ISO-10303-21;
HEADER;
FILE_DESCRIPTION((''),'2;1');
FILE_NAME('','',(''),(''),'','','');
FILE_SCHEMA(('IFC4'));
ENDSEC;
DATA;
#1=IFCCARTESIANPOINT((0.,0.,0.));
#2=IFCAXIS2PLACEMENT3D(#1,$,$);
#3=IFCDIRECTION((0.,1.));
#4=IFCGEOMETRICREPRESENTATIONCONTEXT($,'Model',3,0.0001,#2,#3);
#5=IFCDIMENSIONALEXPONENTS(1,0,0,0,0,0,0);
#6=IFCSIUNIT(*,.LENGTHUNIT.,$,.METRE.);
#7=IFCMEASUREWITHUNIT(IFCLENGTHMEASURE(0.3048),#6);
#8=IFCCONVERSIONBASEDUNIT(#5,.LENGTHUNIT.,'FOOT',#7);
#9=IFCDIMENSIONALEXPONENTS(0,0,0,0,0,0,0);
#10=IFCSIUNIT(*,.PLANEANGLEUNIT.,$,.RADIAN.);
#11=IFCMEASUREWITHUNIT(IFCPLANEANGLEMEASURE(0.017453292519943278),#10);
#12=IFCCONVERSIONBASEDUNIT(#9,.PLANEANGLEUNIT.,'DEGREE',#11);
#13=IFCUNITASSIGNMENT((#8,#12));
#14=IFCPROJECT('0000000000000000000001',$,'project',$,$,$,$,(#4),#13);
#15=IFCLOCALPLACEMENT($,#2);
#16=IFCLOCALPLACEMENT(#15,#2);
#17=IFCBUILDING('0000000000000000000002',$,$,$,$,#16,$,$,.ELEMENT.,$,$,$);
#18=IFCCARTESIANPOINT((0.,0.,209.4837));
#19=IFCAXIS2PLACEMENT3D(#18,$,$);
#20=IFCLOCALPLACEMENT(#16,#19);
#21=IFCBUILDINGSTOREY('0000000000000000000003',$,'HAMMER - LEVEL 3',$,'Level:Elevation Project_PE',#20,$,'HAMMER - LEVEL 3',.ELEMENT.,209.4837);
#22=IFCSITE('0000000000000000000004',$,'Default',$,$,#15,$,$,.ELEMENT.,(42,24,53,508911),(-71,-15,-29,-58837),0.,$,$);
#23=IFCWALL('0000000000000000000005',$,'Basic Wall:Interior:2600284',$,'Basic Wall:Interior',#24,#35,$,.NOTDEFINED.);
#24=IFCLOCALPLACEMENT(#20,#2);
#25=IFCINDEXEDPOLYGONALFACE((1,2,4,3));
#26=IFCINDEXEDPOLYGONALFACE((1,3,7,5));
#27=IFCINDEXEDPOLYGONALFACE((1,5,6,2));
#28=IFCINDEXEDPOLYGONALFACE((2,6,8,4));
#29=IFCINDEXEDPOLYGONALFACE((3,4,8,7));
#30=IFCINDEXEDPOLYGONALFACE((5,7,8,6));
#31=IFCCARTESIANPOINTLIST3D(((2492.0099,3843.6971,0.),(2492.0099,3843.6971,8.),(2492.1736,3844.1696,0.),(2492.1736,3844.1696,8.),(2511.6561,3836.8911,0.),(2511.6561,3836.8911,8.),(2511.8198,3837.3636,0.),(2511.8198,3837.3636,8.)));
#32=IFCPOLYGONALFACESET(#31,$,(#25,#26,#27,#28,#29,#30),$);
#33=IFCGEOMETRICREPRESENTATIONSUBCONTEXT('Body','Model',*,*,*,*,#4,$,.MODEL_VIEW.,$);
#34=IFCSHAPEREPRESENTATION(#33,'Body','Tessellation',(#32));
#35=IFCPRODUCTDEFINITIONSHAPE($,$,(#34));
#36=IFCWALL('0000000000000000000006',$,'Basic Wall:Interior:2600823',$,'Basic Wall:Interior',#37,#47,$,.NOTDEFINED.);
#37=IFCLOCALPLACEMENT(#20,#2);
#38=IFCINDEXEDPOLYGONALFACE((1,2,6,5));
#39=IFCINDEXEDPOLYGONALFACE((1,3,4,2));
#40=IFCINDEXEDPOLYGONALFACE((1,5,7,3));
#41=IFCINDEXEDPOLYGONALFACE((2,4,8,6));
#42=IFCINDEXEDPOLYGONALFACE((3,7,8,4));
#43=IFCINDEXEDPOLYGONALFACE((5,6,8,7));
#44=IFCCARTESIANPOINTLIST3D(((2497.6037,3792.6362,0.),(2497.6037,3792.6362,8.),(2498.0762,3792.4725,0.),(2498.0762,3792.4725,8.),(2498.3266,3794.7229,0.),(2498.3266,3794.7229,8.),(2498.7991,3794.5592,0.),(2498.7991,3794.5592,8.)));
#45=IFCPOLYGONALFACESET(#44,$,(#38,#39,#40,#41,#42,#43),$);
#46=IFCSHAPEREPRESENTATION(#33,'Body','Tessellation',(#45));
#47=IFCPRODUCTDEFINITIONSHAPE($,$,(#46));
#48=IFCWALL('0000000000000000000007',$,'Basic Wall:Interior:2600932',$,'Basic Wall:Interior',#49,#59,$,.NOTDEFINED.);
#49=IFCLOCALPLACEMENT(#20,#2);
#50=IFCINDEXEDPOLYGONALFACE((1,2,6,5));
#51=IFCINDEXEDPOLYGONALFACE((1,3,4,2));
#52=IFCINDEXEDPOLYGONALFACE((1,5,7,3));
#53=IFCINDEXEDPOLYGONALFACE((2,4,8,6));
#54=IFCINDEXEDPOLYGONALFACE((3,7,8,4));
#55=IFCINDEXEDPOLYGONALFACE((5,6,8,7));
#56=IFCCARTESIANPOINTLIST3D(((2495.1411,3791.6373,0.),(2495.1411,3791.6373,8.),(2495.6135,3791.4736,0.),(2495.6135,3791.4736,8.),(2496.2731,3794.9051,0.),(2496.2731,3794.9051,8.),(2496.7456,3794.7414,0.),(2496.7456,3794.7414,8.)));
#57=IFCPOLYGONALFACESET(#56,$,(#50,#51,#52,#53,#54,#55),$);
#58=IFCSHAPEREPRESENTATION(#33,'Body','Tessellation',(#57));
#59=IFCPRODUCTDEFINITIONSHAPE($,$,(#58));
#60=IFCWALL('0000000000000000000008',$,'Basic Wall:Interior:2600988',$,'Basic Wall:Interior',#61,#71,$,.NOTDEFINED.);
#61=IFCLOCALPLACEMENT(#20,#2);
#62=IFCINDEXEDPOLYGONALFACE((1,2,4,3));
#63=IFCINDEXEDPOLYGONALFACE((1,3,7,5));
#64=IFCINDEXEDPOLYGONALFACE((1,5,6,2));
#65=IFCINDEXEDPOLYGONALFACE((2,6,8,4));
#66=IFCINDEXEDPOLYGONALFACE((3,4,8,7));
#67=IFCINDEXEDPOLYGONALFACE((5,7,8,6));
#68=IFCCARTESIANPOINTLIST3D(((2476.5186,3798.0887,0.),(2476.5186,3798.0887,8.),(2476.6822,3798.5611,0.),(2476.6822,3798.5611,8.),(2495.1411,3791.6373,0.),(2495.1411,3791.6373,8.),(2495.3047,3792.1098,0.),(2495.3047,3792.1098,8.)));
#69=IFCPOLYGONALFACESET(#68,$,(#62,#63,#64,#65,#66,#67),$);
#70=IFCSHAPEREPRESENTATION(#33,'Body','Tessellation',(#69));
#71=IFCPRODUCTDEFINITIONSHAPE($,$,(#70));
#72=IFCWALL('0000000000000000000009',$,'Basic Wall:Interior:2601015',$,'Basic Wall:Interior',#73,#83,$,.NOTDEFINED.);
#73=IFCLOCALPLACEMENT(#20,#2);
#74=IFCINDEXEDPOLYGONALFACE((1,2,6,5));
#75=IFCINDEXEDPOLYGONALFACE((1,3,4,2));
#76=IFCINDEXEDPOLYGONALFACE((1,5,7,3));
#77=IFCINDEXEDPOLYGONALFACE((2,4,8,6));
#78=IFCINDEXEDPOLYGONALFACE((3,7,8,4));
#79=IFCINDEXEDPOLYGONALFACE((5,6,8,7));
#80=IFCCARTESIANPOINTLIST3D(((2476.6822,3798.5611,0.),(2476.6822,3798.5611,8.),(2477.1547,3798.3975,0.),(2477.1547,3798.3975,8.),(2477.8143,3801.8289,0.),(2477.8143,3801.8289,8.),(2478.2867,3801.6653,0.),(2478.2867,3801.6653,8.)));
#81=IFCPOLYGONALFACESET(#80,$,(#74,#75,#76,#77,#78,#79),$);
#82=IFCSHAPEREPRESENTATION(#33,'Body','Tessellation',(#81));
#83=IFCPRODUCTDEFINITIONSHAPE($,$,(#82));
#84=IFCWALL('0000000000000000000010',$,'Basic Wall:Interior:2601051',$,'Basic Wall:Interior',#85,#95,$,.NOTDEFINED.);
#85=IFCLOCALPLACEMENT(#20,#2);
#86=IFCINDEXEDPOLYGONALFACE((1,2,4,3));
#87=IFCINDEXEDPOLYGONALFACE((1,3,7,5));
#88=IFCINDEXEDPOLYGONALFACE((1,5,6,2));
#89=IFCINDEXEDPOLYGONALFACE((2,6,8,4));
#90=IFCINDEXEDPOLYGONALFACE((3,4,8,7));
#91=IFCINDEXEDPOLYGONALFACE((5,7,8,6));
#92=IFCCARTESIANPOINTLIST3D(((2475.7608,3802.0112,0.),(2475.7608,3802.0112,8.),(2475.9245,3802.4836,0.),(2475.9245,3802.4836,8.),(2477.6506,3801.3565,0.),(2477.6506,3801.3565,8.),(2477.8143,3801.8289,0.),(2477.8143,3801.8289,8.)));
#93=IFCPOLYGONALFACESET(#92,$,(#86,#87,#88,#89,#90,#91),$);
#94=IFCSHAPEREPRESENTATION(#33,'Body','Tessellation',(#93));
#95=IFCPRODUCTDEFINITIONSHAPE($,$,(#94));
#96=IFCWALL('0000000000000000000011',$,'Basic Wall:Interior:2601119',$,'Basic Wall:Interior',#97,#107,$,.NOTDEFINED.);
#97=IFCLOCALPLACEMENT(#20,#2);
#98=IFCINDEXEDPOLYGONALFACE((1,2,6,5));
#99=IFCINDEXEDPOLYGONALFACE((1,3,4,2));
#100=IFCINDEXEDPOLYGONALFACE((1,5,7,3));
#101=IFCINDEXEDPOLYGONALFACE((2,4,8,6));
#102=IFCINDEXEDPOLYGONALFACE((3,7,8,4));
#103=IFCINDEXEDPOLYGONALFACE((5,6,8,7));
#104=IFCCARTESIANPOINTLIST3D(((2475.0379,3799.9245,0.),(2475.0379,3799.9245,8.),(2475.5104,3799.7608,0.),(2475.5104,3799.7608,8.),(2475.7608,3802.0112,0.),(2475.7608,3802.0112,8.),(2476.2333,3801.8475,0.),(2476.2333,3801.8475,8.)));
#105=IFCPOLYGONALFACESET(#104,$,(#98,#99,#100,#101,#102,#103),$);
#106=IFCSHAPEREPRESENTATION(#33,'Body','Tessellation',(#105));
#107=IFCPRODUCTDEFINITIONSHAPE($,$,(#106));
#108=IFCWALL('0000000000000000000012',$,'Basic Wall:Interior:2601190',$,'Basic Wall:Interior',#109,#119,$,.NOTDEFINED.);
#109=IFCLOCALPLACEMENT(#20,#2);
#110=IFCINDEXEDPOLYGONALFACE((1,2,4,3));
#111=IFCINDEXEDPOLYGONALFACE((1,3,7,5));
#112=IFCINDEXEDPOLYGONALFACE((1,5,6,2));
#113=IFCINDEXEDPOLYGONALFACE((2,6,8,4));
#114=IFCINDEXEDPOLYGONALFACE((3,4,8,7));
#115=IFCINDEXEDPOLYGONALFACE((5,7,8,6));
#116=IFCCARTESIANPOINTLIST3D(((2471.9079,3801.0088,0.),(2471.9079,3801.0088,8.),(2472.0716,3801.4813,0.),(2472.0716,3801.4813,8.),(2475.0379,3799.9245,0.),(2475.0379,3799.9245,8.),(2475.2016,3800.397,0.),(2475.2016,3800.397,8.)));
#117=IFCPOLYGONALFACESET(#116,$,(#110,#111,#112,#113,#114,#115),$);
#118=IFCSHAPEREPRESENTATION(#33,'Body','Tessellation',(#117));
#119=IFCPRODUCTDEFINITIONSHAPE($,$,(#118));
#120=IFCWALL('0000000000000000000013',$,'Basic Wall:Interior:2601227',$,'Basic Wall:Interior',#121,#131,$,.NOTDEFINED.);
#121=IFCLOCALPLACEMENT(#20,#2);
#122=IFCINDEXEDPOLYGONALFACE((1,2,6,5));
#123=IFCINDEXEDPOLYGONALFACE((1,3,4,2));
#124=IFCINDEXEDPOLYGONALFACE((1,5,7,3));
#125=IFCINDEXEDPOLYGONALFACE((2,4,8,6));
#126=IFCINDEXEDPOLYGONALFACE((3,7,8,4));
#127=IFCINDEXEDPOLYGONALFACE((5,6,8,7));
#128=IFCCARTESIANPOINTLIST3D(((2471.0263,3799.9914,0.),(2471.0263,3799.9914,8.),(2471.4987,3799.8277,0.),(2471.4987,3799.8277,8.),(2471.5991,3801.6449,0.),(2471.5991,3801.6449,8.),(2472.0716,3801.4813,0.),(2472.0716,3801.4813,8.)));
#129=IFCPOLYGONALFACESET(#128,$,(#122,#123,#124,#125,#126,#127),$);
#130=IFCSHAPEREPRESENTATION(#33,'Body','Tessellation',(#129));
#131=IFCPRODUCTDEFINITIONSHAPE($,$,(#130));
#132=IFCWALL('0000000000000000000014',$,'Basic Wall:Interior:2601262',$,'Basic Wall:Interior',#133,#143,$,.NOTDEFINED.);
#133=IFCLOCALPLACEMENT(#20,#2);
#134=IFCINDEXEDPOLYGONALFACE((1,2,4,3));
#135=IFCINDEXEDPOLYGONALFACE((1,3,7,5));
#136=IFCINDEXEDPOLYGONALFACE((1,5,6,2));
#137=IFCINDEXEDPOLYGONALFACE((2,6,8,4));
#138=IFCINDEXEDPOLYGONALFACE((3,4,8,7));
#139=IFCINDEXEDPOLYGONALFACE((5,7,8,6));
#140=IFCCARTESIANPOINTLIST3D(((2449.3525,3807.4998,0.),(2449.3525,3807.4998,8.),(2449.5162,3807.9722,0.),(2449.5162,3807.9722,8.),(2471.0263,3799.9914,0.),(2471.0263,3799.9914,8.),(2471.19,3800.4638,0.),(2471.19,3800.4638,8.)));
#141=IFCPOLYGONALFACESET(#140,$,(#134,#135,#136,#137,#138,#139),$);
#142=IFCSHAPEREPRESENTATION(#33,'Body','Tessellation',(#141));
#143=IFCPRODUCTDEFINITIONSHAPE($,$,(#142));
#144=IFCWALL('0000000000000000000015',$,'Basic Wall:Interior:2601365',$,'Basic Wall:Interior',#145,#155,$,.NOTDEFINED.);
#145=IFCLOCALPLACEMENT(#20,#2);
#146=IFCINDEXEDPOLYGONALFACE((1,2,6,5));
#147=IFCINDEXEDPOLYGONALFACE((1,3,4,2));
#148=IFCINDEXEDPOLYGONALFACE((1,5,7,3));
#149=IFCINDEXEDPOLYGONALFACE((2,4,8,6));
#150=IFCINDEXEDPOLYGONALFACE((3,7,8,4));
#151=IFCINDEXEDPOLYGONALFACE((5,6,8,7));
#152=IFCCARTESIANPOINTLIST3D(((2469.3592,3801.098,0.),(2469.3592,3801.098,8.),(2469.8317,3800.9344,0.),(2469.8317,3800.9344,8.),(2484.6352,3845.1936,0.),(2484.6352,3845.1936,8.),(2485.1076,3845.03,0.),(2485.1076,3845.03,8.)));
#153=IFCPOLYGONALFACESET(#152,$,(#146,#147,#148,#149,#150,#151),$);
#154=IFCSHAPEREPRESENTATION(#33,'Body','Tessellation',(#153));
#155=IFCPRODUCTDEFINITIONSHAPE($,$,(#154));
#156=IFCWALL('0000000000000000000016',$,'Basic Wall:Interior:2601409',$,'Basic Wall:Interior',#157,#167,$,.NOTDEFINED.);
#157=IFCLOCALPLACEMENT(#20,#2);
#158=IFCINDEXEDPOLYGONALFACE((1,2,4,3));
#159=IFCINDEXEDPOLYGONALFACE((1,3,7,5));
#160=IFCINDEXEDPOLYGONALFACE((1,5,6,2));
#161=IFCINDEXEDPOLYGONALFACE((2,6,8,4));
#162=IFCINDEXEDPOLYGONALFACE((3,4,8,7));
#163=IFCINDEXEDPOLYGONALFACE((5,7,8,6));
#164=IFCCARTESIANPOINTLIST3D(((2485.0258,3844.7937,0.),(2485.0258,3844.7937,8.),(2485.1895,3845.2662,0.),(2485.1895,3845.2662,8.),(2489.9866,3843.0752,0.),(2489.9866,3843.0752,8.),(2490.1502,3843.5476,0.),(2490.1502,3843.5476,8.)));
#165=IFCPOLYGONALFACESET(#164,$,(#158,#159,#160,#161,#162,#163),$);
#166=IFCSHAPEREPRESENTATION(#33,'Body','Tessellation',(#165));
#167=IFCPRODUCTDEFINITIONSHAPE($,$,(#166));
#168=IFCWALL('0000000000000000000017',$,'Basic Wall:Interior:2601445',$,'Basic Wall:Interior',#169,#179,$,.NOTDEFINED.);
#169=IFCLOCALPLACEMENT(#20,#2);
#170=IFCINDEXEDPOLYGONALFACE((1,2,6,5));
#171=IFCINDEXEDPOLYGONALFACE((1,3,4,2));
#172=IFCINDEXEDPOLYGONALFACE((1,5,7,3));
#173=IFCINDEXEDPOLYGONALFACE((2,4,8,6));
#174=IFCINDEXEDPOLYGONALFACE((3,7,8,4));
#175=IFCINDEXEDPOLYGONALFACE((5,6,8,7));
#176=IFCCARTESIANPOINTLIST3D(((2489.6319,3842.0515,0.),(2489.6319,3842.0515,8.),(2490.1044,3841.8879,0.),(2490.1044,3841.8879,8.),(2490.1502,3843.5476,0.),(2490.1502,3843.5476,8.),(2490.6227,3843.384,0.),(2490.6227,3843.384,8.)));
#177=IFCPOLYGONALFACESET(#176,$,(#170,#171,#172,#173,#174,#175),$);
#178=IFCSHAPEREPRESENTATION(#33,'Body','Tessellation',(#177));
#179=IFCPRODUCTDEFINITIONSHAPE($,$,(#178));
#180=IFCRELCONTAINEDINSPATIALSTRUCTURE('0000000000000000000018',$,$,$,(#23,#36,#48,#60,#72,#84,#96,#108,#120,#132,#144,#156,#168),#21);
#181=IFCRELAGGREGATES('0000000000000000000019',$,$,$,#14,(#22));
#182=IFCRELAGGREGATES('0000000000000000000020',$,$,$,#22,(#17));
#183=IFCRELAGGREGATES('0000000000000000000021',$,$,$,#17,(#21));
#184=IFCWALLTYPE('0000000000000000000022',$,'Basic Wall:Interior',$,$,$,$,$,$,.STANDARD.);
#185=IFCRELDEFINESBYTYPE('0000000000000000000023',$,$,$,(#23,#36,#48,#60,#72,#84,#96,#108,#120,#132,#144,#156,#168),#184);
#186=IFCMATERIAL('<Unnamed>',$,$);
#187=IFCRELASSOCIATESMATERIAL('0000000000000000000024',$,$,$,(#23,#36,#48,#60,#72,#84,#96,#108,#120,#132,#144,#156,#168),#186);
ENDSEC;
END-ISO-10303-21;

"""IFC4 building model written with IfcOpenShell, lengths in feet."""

from ifc_helpers import new_model, entity, si_unit, converted_unit, direction, frame, origin, place, context, subcontext, project, spatial, indexed_curve, outline, extrude, material, type_object, element, save


model = new_model("IFC4")

# Units and contexts
model_context = context("Model", 3, precision=0.0001, world=origin(), true_north=direction((0.0, 1.0)))
body_context = subcontext(model_context, "Body", "Model", "MODEL_VIEW")
ifc_project = project(units=[converted_unit("LENGTHUNIT", "FOOT", entity("IfcLengthMeasure", 0.3048), si_unit("LENGTHUNIT", "METRE"), dimensions=[1, 0, 0, 0, 0, 0, 0]), converted_unit("PLANEANGLEUNIT", "DEGREE", entity("IfcPlaneAngleMeasure", 0.017453292519943278), si_unit("PLANEANGLEUNIT", "RADIAN"), dimensions=[0, 0, 0, 0, 0, 0, 0])], contexts=[model_context])

# Site, building, storey
site_placement = place(None, origin())
site = spatial("IfcSite", under=ifc_project, at=site_placement, Name="Default", CompositionType="ELEMENT", RefLatitude=(42, 24, 53, 508911), RefLongitude=(-71, -15, -29, -58837), RefElevation=0.0)
building_placement = place(site_placement, origin())
building = spatial("IfcBuilding", under=site, at=building_placement, CompositionType="ELEMENT")
storey_placement = place(building_placement, frame((0.0, 0.0, 209.4837)))
storey = spatial("IfcBuildingStorey", under=building, at=storey_placement, Name="HAMMER - LEVEL 3", ObjectType="Level:Elevation Project_PE", LongName="HAMMER - LEVEL 3", CompositionType="ELEMENT", Elevation=209.4837)

# Walls
ifc_material = material(Name="<Unnamed>")
wall_type = type_object("IfcWallType", Name="Basic Wall:Interior", PredefinedType="STANDARD")
wall_1_placement = place(storey_placement, frame((2492.0918, 3843.9333, 0.0), z_axis=(0.0, 0.0, 1.0), x_axis=(0.944906, -0.327342, 0.0)))
element("IfcWall", 1, at=wall_1_placement, inside=storey, type_object=wall_type, material=ifc_material, Name="Basic Wall:Interior:2600284", ObjectType="Basic Wall:Interior", PredefinedType="NOTDEFINED", context=body_context, shape_type="SweptSolid", body=[
    extrude(outline(indexed_curve([(20.7917, 0.25), (0.0, 0.25), (0.0, -0.25), (20.7917, -0.25), (20.7917, 0.25)], self_intersect=False)), origin(), (0.0, 0.0, 1.0), 8.0),
])
wall_2_placement = place(storey_placement, frame((2497.84, 3792.5544, 0.0), z_axis=(0.0, 0.0, 1.0), x_axis=(0.327342, 0.944906, 0.0)))
element("IfcWall", 2, at=wall_2_placement, inside=storey, type_object=wall_type, material=ifc_material, Name="Basic Wall:Interior:2600823", ObjectType="Basic Wall:Interior", PredefinedType="NOTDEFINED", context=body_context, shape_type="SweptSolid", body=[
    extrude(outline(indexed_curve([(2.2083, 0.25), (0.0, 0.25), (0.0, -0.25), (2.2083, -0.25), (2.2083, 0.25)], self_intersect=False)), origin(), (0.0, 0.0, 1.0), 8.0),
])
wall_3_placement = place(storey_placement, frame((2496.5094, 3794.8233, 0.0), z_axis=(0.0, 0.0, 1.0), x_axis=(-0.327342, -0.944906, 0.0)))
element("IfcWall", 3, at=wall_3_placement, inside=storey, type_object=wall_type, material=ifc_material, Name="Basic Wall:Interior:2600932", ObjectType="Basic Wall:Interior", PredefinedType="NOTDEFINED", context=body_context, shape_type="SweptSolid", body=[
    extrude(outline(indexed_curve([(3.4583, 0.25), (0.0, 0.25), (0.0, -0.25), (3.4583, -0.25), (3.4583, 0.25)], self_intersect=False)), origin(), (0.0, 0.0, 1.0), 8.0),
])
wall_4_placement = place(storey_placement, frame((2495.2229, 3791.8735, 0.0), z_axis=(0.0, 0.0, 1.0), x_axis=(-0.944906, 0.327342, 0.0)))
element("IfcWall", 4, at=wall_4_placement, inside=storey, type_object=wall_type, material=ifc_material, Name="Basic Wall:Interior:2600988", ObjectType="Basic Wall:Interior", PredefinedType="NOTDEFINED", context=body_context, shape_type="SweptSolid", body=[
    extrude(outline(indexed_curve([(19.7083, 0.25), (0.0, 0.25), (0.0, -0.25), (19.7083, -0.25), (19.7083, 0.25)], self_intersect=False)), origin(), (0.0, 0.0, 1.0), 8.0),
])
wall_5_placement = place(storey_placement, frame((2476.9185, 3798.4793, 0.0), z_axis=(0.0, 0.0, 1.0), x_axis=(0.327342, 0.944906, 0.0)))
element("IfcWall", 5, at=wall_5_placement, inside=storey, type_object=wall_type, material=ifc_material, Name="Basic Wall:Interior:2601015", ObjectType="Basic Wall:Interior", PredefinedType="NOTDEFINED", context=body_context, shape_type="SweptSolid", body=[
    extrude(outline(indexed_curve([(3.4583, 0.25), (0.0, 0.25), (0.0, -0.25), (3.4583, -0.25), (3.4583, 0.25)], self_intersect=False)), origin(), (0.0, 0.0, 1.0), 8.0),
])
wall_6_placement = place(storey_placement, frame((2477.7325, 3801.5927, 0.0), z_axis=(0.0, 0.0, 1.0), x_axis=(-0.944906, 0.327342, 0.0)))
element("IfcWall", 6, at=wall_6_placement, inside=storey, type_object=wall_type, material=ifc_material, Name="Basic Wall:Interior:2601051", ObjectType="Basic Wall:Interior", PredefinedType="NOTDEFINED", context=body_context, shape_type="SweptSolid", body=[
    extrude(outline(indexed_curve([(2.0, 0.25), (0.0, 0.25), (0.0, -0.25), (2.0, -0.25), (2.0, 0.25)], self_intersect=False)), origin(), (0.0, 0.0, 1.0), 8.0),
])
wall_7_placement = place(storey_placement, frame((2475.997, 3801.9293, 0.0), z_axis=(0.0, 0.0, 1.0), x_axis=(-0.327342, -0.944906, 0.0)))
element("IfcWall", 7, at=wall_7_placement, inside=storey, type_object=wall_type, material=ifc_material, Name="Basic Wall:Interior:2601119", ObjectType="Basic Wall:Interior", PredefinedType="NOTDEFINED", context=body_context, shape_type="SweptSolid", body=[
    extrude(outline(indexed_curve([(2.2083, 0.25), (0.0, 0.25), (0.0, -0.25), (2.2083, -0.25), (2.2083, 0.25)], self_intersect=False)), origin(), (0.0, 0.0, 1.0), 8.0),
])
wall_8_placement = place(storey_placement, frame((2475.1198, 3800.1607, 0.0), z_axis=(0.0, 0.0, 1.0), x_axis=(-0.944906, 0.327342, 0.0)))
element("IfcWall", 8, at=wall_8_placement, inside=storey, type_object=wall_type, material=ifc_material, Name="Basic Wall:Interior:2601190", ObjectType="Basic Wall:Interior", PredefinedType="NOTDEFINED", context=body_context, shape_type="SweptSolid", body=[
    extrude(outline(indexed_curve([(3.3125, 0.25), (0.0, 0.25), (0.0, -0.25), (3.3125, -0.25), (3.3125, 0.25)], self_intersect=False)), origin(), (0.0, 0.0, 1.0), 8.0),
])
wall_9_placement = place(storey_placement, frame((2471.8354, 3801.5631, 0.0), z_axis=(0.0, 0.0, 1.0), x_axis=(-0.327342, -0.944906, 0.0)))
element("IfcWall", 9, at=wall_9_placement, inside=storey, type_object=wall_type, material=ifc_material, Name="Basic Wall:Interior:2601227", ObjectType="Basic Wall:Interior", PredefinedType="NOTDEFINED", context=body_context, shape_type="SweptSolid", body=[
    extrude(outline(indexed_curve([(1.75, 0.25), (0.0, 0.25), (0.0, -0.25), (1.75, -0.25), (1.75, 0.25)], self_intersect=False)), origin(), (0.0, 0.0, 1.0), 8.0),
])
wall_10_placement = place(storey_placement, frame((2471.1081, 3800.2276, 0.0), z_axis=(0.0, 0.0, 1.0), x_axis=(-0.944906, 0.327342, 0.0)))
element("IfcWall", 10, at=wall_10_placement, inside=storey, type_object=wall_type, material=ifc_material, Name="Basic Wall:Interior:2601262", ObjectType="Basic Wall:Interior", PredefinedType="NOTDEFINED", context=body_context, shape_type="SweptSolid", body=[
    extrude(outline(indexed_curve([(22.9375, 0.25), (0.0, 0.25), (0.0, -0.25), (22.9375, -0.25), (22.9375, 0.25)], self_intersect=False)), origin(), (0.0, 0.0, 1.0), 8.0),
])
wall_11_placement = place(storey_placement, frame((2469.5954, 3801.0162, 0.0), z_axis=(0.0, 0.0, 1.0), x_axis=(0.327342, 0.944906, 0.0)))
element("IfcWall", 11, at=wall_11_placement, inside=storey, type_object=wall_type, material=ifc_material, Name="Basic Wall:Interior:2601365", ObjectType="Basic Wall:Interior", PredefinedType="NOTDEFINED", context=body_context, shape_type="SweptSolid", body=[
    extrude(outline(indexed_curve([(46.6667, 0.25), (0.0, 0.25), (0.0, -0.25), (46.6667, -0.25), (46.6667, 0.25)], self_intersect=False)), origin(), (0.0, 0.0, 1.0), 8.0),
])
wall_12_placement = place(storey_placement, frame((2485.1076, 3845.03, 0.0), z_axis=(0.0, 0.0, 1.0), x_axis=(0.944906, -0.327342, 0.0)))
element("IfcWall", 12, at=wall_12_placement, inside=storey, type_object=wall_type, material=ifc_material, Name="Basic Wall:Interior:2601409", ObjectType="Basic Wall:Interior", PredefinedType="NOTDEFINED", context=body_context, shape_type="SweptSolid", body=[
    extrude(outline(indexed_curve([(5.25, 0.25), (0.0, 0.25), (0.0, -0.25), (5.25, -0.25), (5.25, 0.25)], self_intersect=False)), origin(), (0.0, 0.0, 1.0), 8.0),
])
wall_13_placement = place(storey_placement, frame((2490.3865, 3843.4658, 0.0), z_axis=(0.0, 0.0, 1.0), x_axis=(-0.327342, -0.944906, 0.0)))
element("IfcWall", 13, at=wall_13_placement, inside=storey, type_object=wall_type, material=ifc_material, Name="Basic Wall:Interior:2601445", ObjectType="Basic Wall:Interior", PredefinedType="NOTDEFINED", context=body_context, shape_type="SweptSolid", body=[
    extrude(outline(indexed_curve([(1.5833, 0.25), (0.0, 0.25), (0.0, -0.25), (1.5833, -0.25), (1.5833, 0.25)], self_intersect=False)), origin(), (0.0, 0.0, 1.0), 8.0),
])

save(model, "model.ifc")
